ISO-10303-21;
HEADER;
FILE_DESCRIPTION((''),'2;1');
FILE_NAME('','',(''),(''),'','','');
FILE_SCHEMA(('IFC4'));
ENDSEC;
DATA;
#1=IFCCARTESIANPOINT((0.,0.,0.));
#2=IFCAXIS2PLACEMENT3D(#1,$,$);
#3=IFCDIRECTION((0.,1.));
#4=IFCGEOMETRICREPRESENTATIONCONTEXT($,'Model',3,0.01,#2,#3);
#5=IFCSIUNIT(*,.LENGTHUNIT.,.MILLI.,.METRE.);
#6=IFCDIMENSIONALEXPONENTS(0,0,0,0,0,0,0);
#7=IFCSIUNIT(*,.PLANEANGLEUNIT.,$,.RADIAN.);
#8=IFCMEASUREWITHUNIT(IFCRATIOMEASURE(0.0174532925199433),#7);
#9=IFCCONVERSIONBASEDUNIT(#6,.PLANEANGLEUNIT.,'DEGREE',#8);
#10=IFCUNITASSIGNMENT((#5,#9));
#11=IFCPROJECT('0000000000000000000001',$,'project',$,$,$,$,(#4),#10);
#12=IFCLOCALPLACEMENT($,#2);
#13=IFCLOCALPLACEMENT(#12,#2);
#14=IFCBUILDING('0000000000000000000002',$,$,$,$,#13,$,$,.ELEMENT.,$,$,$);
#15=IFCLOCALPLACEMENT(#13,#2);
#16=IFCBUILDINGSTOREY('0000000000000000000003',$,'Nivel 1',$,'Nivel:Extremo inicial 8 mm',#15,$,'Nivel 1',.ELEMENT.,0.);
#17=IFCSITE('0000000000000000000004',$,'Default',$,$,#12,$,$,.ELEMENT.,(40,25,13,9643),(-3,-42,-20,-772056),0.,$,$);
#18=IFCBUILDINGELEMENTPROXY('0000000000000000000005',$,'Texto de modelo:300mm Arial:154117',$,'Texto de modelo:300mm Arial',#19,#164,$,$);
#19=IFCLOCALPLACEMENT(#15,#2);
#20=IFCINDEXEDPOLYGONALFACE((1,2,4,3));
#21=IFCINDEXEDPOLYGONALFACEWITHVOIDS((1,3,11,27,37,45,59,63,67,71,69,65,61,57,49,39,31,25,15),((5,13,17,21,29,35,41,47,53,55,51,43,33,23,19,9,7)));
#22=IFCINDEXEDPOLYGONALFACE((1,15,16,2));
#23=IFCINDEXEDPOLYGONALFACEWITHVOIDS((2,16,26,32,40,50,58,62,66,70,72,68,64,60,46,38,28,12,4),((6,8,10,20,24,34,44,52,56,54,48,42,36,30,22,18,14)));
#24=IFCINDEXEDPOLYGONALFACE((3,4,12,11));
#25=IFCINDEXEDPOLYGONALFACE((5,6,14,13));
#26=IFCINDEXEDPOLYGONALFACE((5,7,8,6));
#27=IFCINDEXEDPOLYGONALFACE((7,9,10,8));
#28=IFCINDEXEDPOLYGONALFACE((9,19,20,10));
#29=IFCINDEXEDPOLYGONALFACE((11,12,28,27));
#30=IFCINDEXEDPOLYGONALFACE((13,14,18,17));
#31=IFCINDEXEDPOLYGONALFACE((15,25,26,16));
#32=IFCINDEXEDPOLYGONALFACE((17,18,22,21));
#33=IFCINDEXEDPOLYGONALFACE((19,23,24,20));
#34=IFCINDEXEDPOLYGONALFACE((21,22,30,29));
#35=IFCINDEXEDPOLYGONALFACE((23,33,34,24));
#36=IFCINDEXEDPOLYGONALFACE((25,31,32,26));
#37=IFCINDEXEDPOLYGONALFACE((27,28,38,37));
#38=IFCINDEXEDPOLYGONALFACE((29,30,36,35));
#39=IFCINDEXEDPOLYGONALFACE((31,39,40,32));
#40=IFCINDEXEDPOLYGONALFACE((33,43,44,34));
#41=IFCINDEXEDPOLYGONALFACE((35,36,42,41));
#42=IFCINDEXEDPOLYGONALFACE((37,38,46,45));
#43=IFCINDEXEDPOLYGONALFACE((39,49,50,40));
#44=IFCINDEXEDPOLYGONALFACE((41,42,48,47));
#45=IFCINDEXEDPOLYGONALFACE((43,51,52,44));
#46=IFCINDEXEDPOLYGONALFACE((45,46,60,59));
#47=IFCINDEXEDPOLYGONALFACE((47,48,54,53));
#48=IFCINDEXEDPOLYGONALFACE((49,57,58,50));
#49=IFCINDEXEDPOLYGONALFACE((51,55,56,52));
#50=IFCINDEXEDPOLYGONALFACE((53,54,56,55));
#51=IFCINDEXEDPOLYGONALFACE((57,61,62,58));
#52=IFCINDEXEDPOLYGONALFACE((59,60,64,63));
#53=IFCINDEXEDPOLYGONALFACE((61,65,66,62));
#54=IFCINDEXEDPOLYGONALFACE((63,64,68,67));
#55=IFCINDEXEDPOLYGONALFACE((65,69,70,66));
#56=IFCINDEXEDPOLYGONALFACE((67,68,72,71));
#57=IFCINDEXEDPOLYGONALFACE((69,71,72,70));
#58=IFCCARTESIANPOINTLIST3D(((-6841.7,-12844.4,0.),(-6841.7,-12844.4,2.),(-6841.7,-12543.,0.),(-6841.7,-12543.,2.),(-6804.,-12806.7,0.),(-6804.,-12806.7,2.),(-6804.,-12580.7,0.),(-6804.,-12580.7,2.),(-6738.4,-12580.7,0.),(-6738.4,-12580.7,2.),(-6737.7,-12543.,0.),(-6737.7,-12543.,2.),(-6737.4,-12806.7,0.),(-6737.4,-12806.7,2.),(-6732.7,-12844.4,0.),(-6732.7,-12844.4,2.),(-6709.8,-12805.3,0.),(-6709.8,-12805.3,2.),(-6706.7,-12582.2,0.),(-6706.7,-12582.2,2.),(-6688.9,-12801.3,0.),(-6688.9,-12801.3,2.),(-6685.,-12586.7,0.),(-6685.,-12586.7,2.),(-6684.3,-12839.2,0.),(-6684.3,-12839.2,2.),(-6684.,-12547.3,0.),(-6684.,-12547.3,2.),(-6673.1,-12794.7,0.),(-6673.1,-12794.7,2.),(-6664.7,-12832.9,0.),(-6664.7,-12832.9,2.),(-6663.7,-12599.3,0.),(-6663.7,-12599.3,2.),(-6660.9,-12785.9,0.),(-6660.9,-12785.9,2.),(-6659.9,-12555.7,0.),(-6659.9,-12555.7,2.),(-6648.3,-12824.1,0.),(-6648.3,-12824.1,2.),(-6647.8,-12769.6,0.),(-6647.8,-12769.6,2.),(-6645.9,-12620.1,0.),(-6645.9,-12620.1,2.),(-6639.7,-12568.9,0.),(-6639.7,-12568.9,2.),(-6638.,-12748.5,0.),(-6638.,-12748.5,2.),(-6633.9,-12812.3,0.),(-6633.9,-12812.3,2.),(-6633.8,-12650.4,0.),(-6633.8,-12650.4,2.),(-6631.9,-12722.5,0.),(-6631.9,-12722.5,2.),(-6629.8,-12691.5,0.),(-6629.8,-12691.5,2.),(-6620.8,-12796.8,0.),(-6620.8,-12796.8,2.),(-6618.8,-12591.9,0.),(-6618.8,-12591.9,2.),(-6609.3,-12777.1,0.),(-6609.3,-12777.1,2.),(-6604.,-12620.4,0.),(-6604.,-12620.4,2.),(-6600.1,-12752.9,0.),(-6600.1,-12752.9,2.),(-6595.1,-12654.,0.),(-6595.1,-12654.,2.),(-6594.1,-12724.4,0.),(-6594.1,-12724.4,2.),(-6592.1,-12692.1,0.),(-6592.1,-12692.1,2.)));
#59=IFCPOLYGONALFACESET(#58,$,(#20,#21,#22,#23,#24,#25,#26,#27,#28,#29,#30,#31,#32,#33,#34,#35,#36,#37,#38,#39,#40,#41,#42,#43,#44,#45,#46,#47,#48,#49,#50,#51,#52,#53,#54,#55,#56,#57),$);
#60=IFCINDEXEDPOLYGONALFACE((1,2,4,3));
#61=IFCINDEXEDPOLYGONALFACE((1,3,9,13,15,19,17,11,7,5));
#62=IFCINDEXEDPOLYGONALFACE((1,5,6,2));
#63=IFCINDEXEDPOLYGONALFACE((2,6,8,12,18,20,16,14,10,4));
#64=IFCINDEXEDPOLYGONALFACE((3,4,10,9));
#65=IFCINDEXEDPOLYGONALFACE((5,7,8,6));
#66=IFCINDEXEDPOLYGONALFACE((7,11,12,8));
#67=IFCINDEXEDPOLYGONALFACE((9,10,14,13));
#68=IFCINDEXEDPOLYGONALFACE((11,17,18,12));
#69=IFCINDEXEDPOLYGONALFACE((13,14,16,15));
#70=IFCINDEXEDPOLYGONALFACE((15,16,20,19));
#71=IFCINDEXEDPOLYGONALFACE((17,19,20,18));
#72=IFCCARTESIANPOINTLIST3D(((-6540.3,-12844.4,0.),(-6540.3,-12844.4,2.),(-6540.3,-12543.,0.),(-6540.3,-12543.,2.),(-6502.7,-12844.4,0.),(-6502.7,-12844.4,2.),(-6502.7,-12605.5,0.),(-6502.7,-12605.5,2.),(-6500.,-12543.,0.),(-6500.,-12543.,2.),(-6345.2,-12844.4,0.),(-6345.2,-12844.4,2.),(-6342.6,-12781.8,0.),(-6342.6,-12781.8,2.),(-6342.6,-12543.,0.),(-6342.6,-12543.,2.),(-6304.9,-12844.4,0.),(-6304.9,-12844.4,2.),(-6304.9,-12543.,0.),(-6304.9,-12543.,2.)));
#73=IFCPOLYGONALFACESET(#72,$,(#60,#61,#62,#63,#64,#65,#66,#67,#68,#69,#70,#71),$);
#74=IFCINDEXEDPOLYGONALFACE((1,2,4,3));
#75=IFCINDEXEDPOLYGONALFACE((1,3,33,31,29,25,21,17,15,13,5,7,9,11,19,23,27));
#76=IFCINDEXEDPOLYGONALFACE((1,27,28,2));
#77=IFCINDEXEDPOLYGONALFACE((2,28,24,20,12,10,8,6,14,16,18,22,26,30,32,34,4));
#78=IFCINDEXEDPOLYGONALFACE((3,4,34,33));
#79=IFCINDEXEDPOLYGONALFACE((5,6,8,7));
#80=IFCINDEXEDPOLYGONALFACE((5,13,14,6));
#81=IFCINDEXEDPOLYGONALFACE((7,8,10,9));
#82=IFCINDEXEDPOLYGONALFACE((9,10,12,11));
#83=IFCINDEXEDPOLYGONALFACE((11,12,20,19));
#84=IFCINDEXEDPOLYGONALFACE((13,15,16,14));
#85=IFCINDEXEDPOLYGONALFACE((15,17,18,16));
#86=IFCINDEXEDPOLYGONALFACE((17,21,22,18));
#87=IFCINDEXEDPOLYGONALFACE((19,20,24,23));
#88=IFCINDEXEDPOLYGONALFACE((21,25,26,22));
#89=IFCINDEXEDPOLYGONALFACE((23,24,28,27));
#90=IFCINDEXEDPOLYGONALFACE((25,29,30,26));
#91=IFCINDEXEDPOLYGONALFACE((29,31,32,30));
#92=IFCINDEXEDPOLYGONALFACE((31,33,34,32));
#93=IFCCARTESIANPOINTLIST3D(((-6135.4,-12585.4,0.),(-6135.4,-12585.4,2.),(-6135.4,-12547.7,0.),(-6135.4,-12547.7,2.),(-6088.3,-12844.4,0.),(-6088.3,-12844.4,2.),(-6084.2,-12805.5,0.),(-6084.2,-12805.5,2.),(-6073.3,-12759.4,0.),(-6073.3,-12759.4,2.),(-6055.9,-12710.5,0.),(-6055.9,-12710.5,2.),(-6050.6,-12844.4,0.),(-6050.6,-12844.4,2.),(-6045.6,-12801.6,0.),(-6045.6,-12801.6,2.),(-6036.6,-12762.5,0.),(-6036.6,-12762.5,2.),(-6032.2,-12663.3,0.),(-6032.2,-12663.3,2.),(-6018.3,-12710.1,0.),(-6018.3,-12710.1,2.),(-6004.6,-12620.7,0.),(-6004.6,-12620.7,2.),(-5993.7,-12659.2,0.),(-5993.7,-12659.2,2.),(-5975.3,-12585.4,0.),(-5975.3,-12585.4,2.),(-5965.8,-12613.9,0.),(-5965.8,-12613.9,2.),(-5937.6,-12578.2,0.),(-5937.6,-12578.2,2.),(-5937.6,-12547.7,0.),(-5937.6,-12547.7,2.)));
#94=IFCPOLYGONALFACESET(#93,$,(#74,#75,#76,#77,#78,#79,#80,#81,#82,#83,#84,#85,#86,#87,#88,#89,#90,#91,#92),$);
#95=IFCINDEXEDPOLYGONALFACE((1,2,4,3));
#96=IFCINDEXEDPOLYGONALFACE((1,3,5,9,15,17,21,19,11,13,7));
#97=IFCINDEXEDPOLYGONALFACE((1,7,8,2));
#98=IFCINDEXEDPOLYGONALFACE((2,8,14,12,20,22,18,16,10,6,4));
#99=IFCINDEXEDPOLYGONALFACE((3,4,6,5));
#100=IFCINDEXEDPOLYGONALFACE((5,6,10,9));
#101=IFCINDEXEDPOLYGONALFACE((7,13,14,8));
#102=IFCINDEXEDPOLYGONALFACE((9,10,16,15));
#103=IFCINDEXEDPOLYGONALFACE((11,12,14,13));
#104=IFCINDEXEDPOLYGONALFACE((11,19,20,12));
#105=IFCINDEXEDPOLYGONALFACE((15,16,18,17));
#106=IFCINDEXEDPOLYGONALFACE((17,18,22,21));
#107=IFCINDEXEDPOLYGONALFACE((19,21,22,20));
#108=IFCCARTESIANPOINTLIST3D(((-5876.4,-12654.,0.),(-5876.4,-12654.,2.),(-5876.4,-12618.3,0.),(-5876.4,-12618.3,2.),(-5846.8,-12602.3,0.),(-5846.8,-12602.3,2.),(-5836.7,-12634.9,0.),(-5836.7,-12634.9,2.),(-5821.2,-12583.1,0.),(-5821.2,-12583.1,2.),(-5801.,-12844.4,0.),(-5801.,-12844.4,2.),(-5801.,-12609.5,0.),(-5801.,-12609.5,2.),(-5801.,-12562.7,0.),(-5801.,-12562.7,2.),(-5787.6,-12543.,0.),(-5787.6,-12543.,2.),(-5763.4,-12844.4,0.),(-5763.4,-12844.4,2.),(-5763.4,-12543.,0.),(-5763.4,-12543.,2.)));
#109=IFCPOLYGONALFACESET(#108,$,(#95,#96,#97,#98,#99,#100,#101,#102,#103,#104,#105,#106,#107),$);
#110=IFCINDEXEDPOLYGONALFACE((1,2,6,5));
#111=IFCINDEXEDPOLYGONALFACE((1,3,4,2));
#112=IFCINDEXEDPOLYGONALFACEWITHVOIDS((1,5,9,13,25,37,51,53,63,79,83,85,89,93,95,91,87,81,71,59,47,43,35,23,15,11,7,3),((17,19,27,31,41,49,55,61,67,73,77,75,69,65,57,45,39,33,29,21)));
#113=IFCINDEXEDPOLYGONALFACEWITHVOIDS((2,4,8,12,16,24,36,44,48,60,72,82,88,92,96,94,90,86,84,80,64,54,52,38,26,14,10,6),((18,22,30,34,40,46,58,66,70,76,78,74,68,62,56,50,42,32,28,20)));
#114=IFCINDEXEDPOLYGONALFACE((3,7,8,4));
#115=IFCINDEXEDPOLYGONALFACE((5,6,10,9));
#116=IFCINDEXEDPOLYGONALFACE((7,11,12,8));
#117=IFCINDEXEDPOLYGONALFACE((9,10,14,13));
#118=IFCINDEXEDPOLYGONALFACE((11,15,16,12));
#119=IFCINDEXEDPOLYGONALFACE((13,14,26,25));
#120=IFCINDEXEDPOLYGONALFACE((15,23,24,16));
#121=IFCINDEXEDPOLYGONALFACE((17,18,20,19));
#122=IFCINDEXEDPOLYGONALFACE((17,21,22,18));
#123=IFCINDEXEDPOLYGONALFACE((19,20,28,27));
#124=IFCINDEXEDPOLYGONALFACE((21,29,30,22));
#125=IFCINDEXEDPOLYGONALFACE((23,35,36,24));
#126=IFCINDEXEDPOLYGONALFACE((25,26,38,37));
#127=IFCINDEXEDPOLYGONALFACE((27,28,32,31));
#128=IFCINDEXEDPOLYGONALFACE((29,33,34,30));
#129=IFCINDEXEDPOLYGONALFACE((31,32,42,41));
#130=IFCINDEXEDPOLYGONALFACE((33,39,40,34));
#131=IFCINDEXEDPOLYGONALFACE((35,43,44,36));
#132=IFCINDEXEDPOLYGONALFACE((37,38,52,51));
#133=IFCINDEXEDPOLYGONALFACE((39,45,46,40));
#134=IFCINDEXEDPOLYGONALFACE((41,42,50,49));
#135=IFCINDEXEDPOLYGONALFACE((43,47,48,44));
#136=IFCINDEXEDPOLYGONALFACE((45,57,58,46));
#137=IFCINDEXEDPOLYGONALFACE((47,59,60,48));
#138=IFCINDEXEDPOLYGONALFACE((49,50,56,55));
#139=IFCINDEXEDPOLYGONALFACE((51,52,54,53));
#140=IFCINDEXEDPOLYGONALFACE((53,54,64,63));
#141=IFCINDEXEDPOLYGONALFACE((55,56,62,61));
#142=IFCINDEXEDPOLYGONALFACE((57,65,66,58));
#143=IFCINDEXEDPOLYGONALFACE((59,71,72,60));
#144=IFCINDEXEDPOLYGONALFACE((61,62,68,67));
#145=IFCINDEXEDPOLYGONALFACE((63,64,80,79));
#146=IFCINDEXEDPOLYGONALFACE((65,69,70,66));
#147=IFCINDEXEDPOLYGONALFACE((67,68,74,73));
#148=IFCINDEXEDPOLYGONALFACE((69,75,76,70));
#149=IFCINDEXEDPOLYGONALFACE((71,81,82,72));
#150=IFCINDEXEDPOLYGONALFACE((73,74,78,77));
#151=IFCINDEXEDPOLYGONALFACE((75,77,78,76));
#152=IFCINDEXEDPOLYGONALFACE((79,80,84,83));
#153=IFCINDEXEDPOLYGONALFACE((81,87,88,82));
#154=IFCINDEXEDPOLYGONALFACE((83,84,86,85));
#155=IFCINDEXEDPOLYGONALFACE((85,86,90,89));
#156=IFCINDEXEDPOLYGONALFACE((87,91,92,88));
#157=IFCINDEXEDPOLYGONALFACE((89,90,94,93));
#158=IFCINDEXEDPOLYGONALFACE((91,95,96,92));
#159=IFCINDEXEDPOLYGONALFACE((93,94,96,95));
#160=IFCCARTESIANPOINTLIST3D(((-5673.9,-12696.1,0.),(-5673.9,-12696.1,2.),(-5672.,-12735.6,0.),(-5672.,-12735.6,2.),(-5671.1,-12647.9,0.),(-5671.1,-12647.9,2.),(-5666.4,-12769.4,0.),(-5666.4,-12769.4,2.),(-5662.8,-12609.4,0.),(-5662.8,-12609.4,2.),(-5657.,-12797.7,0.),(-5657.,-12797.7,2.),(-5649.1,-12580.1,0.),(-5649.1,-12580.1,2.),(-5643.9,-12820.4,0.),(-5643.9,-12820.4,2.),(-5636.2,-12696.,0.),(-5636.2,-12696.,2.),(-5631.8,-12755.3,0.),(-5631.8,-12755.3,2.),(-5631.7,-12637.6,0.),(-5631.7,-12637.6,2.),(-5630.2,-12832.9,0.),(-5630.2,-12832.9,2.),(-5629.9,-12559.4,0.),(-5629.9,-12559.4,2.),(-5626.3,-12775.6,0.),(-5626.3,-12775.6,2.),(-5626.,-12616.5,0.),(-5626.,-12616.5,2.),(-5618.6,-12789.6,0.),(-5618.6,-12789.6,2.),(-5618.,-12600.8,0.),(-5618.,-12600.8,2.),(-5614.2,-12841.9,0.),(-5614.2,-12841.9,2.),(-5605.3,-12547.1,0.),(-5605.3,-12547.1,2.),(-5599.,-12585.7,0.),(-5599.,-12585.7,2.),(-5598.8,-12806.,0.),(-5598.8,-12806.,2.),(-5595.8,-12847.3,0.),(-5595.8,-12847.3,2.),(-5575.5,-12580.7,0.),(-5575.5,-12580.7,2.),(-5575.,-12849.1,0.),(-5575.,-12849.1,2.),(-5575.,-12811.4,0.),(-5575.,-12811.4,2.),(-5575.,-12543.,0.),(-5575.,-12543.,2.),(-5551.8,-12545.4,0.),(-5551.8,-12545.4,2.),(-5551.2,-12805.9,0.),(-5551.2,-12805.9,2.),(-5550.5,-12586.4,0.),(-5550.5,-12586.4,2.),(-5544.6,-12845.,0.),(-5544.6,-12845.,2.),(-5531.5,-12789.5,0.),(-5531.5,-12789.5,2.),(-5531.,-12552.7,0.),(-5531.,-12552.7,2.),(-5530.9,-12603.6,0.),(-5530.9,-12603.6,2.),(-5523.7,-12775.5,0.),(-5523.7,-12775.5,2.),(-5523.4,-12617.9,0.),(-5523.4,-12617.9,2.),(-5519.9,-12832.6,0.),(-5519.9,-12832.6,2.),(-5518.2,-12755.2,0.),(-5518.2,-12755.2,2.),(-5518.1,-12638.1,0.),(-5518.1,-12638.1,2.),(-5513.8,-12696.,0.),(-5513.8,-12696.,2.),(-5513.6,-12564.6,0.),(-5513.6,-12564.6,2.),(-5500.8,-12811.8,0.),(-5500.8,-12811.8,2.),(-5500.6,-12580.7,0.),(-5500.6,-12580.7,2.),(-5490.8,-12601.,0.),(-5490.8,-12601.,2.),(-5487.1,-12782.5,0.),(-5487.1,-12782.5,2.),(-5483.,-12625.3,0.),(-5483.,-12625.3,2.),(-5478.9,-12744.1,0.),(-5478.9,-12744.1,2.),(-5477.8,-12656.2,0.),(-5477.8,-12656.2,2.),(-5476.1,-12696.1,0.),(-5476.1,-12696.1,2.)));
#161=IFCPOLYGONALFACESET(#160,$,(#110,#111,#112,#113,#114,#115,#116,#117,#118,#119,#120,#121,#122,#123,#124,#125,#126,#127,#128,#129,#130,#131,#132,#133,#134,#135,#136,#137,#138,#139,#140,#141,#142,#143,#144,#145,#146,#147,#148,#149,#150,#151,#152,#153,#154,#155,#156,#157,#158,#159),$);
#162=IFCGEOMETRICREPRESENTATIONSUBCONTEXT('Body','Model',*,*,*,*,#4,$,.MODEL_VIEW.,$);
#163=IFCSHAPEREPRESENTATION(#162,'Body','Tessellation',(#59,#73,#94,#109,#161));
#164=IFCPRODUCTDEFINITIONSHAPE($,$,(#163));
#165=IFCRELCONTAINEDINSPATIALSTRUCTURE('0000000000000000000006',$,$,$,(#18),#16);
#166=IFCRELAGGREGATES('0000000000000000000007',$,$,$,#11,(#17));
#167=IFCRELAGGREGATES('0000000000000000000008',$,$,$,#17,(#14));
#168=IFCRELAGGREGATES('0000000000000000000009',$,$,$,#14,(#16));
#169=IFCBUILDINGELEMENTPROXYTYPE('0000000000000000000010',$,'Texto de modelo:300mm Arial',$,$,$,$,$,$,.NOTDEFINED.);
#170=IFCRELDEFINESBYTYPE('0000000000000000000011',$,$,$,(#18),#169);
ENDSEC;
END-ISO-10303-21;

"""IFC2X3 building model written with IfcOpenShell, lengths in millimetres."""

from ifc_helpers import new_model, entity, si_unit, converted_unit, direction, frame, origin, place, context, subcontext, project, spatial, polyline, outline, extrude, type_object, element, save


model = new_model("IFC2X3")

# Units and contexts
model_context = context("Model", 3, precision=0.01, world=origin(), true_north=direction((0.0, 1.0)))
body_context = subcontext(model_context, "Body", "Model", "MODEL_VIEW")
ifc_project = project(units=[si_unit("LENGTHUNIT", "METRE", prefix="MILLI"), converted_unit("PLANEANGLEUNIT", "DEGREE", entity("IfcRatioMeasure", 0.0174532925199433), si_unit("PLANEANGLEUNIT", "RADIAN"), dimensions=[0, 0, 0, 0, 0, 0, 0])], contexts=[model_context])

# Site, building, storey
site_placement = place(None, origin())
site = spatial("IfcSite", under=ifc_project, at=site_placement, Name="Default", CompositionType="ELEMENT", RefLatitude=(40, 25, 13, 9643), RefLongitude=(-3, -42, -20, -772056), RefElevation=0.0)
building_placement = place(site_placement, origin())
building = spatial("IfcBuilding", under=site, at=building_placement, CompositionType="ELEMENT")
storey_placement = place(building_placement, origin())
storey = spatial("IfcBuildingStorey", under=building, at=storey_placement, Name="Nivel 1", ObjectType="Nivel:Extremo inicial 8 mm", LongName="Nivel 1", CompositionType="ELEMENT", Elevation=0.0)

# Building element proxy
building_element_proxy_type_1 = type_object("IfcBuildingElementProxyType", Name="Texto de modelo:300mm Arial", PredefinedType="NOTDEFINED")
proxy_1_placement = place(storey_placement, frame((-6841.7, -12849.1, 0.0)))
element("IfcBuildingElementProxy", 1, at=proxy_1_placement, inside=storey, type_object=building_element_proxy_type_1, Name="Texto de modelo:300mm Arial:154117", ObjectType="Texto de modelo:300mm Arial", context=body_context, shape_type="SweptSolid", body=[
    extrude(outline(polyline([(-178.4, -141.0), (-69.4, -141.0), (-21.0, -135.8), (-1.4, -129.5), (15.0, -120.7), (29.4, -108.9), (42.6, -93.4), (54.0, -73.7), (63.2, -49.5), (69.2, -21.0), (71.2, 11.3), (68.2, 49.4), (59.3, 83.0), (44.5, 111.5), (23.7, 134.5), (3.4, 147.7), (-20.6, 156.1), (-74.4, 160.4), (-178.4, 160.4), (-178.4, -141.0)]), holes=[polyline([(-140.7, -103.3), (-140.7, 122.7), (-75.1, 122.7), (-43.3, 121.2), (-21.7, 116.7), (-0.4, 104.1), (17.4, 83.3), (29.5, 53.0), (33.5, 11.9), (31.5, -19.1), (25.3, -45.1), (15.5, -66.2), (2.4, -82.5), (-9.8, -91.3), (-25.6, -97.9), (-46.5, -101.9), (-74.1, -103.3), (-140.7, -103.3)])]), frame((178.4, 145.7, 0.0)), (0.0, 0.0, 1.0), 2.0),
    extrude(outline(polyline([(-117.7, -150.7), (-80.1, -150.7), (-80.1, 88.1), (77.4, -150.7), (117.7, -150.7), (117.7, 150.7), (80.1, 150.7), (80.1, -88.1), (-77.4, 150.7), (-117.7, 150.7), (-117.7, -150.7)])), frame((419.1, 155.4, 0.0)), (0.0, 0.0, 1.0), 2.0),
    extrude(outline(polyline([(-101.8, -99.3), (-101.8, -137.0), (96.0, -137.0), (96.0, -106.5), (67.8, -70.9), (39.9, -25.5), (15.2, 25.4), (-3.1, 77.8), (-12.1, 116.9), (-17.1, 159.7), (-54.7, 159.7), (-50.7, 120.8), (-39.8, 74.7), (-22.3, 25.8), (1.3, -21.4), (29.0, -64.0), (58.3, -99.3), (-101.8, -99.3)])), frame((808.2, 164.4, 0.0), z_axis=(0.0, 0.0, -1.0), x_axis=(1.0, 0.0, 0.0)), (0.0, 0.0, -1.0), 2.0),
    extrude(outline(polyline([(-204.4, -52.5), (97.0, -52.5), (97.0, -28.2), (77.2, -14.9), (56.9, 5.3), (37.7, 30.9), (21.6, 60.5), (-14.0, 60.5), (5.0, 20.8), (30.4, -14.9), (-204.4, -14.9), (-204.4, -52.5)])), frame((1025.8, 209.1, 0.0), z_axis=(0.0, 0.0, 1.0), x_axis=(0.0, 1.0, 0.0)), (0.0, 0.0, 1.0), 2.0),
    extrude(outline(polyline([(-5.6, -99.5), (33.9, -99.5), (68.0, -95.5), (96.7, -87.5), (120.0, -75.5), (133.2, -62.4), (142.9, -46.8), (149.1, -28.7), (151.9, -8.0), (149.2, 22.6), (138.0, 47.8), (118.2, 67.9), (89.5, 82.9), (51.6, 93.0), (3.8, 98.0), (-36.2, 98.2), (-67.3, 94.5), (-91.9, 87.9), (-112.6, 79.0), (-129.4, 66.8), (-142.0, 50.0), (-150.3, 29.6), (-153.8, 6.5), (-151.2, -23.9), (-140.1, -49.1), (-120.3, -69.2), (-91.7, -84.4), (-53.6, -94.5), (-5.6, -99.5)]), holes=[polyline([(-3.9, -61.9), (-62.1, -54.6), (-82.9, -47.9), (-98.1, -39.2), (-112.3, -19.5), (-116.2, 4.3), (-109.3, 28.9), (-91.2, 47.7), (-76.5, 54.5), (-56.1, 58.9), (1.9, 60.4), (60.8, 53.2), (80.8, 46.7), (94.5, 38.3), (109.9, 17.8), (114.3, -6.3), (107.7, -29.8), (90.4, -48.7), (76.0, -55.8), (55.5, -60.3), (-3.9, -61.9)])]), frame((1267.5, 152.1, 0.0), z_axis=(0.0, 0.0, 1.0), x_axis=(0.047515, -0.998871, 0.0)), (0.0, 0.0, 1.0), 2.0),
])

save(model, "model.ifc")
